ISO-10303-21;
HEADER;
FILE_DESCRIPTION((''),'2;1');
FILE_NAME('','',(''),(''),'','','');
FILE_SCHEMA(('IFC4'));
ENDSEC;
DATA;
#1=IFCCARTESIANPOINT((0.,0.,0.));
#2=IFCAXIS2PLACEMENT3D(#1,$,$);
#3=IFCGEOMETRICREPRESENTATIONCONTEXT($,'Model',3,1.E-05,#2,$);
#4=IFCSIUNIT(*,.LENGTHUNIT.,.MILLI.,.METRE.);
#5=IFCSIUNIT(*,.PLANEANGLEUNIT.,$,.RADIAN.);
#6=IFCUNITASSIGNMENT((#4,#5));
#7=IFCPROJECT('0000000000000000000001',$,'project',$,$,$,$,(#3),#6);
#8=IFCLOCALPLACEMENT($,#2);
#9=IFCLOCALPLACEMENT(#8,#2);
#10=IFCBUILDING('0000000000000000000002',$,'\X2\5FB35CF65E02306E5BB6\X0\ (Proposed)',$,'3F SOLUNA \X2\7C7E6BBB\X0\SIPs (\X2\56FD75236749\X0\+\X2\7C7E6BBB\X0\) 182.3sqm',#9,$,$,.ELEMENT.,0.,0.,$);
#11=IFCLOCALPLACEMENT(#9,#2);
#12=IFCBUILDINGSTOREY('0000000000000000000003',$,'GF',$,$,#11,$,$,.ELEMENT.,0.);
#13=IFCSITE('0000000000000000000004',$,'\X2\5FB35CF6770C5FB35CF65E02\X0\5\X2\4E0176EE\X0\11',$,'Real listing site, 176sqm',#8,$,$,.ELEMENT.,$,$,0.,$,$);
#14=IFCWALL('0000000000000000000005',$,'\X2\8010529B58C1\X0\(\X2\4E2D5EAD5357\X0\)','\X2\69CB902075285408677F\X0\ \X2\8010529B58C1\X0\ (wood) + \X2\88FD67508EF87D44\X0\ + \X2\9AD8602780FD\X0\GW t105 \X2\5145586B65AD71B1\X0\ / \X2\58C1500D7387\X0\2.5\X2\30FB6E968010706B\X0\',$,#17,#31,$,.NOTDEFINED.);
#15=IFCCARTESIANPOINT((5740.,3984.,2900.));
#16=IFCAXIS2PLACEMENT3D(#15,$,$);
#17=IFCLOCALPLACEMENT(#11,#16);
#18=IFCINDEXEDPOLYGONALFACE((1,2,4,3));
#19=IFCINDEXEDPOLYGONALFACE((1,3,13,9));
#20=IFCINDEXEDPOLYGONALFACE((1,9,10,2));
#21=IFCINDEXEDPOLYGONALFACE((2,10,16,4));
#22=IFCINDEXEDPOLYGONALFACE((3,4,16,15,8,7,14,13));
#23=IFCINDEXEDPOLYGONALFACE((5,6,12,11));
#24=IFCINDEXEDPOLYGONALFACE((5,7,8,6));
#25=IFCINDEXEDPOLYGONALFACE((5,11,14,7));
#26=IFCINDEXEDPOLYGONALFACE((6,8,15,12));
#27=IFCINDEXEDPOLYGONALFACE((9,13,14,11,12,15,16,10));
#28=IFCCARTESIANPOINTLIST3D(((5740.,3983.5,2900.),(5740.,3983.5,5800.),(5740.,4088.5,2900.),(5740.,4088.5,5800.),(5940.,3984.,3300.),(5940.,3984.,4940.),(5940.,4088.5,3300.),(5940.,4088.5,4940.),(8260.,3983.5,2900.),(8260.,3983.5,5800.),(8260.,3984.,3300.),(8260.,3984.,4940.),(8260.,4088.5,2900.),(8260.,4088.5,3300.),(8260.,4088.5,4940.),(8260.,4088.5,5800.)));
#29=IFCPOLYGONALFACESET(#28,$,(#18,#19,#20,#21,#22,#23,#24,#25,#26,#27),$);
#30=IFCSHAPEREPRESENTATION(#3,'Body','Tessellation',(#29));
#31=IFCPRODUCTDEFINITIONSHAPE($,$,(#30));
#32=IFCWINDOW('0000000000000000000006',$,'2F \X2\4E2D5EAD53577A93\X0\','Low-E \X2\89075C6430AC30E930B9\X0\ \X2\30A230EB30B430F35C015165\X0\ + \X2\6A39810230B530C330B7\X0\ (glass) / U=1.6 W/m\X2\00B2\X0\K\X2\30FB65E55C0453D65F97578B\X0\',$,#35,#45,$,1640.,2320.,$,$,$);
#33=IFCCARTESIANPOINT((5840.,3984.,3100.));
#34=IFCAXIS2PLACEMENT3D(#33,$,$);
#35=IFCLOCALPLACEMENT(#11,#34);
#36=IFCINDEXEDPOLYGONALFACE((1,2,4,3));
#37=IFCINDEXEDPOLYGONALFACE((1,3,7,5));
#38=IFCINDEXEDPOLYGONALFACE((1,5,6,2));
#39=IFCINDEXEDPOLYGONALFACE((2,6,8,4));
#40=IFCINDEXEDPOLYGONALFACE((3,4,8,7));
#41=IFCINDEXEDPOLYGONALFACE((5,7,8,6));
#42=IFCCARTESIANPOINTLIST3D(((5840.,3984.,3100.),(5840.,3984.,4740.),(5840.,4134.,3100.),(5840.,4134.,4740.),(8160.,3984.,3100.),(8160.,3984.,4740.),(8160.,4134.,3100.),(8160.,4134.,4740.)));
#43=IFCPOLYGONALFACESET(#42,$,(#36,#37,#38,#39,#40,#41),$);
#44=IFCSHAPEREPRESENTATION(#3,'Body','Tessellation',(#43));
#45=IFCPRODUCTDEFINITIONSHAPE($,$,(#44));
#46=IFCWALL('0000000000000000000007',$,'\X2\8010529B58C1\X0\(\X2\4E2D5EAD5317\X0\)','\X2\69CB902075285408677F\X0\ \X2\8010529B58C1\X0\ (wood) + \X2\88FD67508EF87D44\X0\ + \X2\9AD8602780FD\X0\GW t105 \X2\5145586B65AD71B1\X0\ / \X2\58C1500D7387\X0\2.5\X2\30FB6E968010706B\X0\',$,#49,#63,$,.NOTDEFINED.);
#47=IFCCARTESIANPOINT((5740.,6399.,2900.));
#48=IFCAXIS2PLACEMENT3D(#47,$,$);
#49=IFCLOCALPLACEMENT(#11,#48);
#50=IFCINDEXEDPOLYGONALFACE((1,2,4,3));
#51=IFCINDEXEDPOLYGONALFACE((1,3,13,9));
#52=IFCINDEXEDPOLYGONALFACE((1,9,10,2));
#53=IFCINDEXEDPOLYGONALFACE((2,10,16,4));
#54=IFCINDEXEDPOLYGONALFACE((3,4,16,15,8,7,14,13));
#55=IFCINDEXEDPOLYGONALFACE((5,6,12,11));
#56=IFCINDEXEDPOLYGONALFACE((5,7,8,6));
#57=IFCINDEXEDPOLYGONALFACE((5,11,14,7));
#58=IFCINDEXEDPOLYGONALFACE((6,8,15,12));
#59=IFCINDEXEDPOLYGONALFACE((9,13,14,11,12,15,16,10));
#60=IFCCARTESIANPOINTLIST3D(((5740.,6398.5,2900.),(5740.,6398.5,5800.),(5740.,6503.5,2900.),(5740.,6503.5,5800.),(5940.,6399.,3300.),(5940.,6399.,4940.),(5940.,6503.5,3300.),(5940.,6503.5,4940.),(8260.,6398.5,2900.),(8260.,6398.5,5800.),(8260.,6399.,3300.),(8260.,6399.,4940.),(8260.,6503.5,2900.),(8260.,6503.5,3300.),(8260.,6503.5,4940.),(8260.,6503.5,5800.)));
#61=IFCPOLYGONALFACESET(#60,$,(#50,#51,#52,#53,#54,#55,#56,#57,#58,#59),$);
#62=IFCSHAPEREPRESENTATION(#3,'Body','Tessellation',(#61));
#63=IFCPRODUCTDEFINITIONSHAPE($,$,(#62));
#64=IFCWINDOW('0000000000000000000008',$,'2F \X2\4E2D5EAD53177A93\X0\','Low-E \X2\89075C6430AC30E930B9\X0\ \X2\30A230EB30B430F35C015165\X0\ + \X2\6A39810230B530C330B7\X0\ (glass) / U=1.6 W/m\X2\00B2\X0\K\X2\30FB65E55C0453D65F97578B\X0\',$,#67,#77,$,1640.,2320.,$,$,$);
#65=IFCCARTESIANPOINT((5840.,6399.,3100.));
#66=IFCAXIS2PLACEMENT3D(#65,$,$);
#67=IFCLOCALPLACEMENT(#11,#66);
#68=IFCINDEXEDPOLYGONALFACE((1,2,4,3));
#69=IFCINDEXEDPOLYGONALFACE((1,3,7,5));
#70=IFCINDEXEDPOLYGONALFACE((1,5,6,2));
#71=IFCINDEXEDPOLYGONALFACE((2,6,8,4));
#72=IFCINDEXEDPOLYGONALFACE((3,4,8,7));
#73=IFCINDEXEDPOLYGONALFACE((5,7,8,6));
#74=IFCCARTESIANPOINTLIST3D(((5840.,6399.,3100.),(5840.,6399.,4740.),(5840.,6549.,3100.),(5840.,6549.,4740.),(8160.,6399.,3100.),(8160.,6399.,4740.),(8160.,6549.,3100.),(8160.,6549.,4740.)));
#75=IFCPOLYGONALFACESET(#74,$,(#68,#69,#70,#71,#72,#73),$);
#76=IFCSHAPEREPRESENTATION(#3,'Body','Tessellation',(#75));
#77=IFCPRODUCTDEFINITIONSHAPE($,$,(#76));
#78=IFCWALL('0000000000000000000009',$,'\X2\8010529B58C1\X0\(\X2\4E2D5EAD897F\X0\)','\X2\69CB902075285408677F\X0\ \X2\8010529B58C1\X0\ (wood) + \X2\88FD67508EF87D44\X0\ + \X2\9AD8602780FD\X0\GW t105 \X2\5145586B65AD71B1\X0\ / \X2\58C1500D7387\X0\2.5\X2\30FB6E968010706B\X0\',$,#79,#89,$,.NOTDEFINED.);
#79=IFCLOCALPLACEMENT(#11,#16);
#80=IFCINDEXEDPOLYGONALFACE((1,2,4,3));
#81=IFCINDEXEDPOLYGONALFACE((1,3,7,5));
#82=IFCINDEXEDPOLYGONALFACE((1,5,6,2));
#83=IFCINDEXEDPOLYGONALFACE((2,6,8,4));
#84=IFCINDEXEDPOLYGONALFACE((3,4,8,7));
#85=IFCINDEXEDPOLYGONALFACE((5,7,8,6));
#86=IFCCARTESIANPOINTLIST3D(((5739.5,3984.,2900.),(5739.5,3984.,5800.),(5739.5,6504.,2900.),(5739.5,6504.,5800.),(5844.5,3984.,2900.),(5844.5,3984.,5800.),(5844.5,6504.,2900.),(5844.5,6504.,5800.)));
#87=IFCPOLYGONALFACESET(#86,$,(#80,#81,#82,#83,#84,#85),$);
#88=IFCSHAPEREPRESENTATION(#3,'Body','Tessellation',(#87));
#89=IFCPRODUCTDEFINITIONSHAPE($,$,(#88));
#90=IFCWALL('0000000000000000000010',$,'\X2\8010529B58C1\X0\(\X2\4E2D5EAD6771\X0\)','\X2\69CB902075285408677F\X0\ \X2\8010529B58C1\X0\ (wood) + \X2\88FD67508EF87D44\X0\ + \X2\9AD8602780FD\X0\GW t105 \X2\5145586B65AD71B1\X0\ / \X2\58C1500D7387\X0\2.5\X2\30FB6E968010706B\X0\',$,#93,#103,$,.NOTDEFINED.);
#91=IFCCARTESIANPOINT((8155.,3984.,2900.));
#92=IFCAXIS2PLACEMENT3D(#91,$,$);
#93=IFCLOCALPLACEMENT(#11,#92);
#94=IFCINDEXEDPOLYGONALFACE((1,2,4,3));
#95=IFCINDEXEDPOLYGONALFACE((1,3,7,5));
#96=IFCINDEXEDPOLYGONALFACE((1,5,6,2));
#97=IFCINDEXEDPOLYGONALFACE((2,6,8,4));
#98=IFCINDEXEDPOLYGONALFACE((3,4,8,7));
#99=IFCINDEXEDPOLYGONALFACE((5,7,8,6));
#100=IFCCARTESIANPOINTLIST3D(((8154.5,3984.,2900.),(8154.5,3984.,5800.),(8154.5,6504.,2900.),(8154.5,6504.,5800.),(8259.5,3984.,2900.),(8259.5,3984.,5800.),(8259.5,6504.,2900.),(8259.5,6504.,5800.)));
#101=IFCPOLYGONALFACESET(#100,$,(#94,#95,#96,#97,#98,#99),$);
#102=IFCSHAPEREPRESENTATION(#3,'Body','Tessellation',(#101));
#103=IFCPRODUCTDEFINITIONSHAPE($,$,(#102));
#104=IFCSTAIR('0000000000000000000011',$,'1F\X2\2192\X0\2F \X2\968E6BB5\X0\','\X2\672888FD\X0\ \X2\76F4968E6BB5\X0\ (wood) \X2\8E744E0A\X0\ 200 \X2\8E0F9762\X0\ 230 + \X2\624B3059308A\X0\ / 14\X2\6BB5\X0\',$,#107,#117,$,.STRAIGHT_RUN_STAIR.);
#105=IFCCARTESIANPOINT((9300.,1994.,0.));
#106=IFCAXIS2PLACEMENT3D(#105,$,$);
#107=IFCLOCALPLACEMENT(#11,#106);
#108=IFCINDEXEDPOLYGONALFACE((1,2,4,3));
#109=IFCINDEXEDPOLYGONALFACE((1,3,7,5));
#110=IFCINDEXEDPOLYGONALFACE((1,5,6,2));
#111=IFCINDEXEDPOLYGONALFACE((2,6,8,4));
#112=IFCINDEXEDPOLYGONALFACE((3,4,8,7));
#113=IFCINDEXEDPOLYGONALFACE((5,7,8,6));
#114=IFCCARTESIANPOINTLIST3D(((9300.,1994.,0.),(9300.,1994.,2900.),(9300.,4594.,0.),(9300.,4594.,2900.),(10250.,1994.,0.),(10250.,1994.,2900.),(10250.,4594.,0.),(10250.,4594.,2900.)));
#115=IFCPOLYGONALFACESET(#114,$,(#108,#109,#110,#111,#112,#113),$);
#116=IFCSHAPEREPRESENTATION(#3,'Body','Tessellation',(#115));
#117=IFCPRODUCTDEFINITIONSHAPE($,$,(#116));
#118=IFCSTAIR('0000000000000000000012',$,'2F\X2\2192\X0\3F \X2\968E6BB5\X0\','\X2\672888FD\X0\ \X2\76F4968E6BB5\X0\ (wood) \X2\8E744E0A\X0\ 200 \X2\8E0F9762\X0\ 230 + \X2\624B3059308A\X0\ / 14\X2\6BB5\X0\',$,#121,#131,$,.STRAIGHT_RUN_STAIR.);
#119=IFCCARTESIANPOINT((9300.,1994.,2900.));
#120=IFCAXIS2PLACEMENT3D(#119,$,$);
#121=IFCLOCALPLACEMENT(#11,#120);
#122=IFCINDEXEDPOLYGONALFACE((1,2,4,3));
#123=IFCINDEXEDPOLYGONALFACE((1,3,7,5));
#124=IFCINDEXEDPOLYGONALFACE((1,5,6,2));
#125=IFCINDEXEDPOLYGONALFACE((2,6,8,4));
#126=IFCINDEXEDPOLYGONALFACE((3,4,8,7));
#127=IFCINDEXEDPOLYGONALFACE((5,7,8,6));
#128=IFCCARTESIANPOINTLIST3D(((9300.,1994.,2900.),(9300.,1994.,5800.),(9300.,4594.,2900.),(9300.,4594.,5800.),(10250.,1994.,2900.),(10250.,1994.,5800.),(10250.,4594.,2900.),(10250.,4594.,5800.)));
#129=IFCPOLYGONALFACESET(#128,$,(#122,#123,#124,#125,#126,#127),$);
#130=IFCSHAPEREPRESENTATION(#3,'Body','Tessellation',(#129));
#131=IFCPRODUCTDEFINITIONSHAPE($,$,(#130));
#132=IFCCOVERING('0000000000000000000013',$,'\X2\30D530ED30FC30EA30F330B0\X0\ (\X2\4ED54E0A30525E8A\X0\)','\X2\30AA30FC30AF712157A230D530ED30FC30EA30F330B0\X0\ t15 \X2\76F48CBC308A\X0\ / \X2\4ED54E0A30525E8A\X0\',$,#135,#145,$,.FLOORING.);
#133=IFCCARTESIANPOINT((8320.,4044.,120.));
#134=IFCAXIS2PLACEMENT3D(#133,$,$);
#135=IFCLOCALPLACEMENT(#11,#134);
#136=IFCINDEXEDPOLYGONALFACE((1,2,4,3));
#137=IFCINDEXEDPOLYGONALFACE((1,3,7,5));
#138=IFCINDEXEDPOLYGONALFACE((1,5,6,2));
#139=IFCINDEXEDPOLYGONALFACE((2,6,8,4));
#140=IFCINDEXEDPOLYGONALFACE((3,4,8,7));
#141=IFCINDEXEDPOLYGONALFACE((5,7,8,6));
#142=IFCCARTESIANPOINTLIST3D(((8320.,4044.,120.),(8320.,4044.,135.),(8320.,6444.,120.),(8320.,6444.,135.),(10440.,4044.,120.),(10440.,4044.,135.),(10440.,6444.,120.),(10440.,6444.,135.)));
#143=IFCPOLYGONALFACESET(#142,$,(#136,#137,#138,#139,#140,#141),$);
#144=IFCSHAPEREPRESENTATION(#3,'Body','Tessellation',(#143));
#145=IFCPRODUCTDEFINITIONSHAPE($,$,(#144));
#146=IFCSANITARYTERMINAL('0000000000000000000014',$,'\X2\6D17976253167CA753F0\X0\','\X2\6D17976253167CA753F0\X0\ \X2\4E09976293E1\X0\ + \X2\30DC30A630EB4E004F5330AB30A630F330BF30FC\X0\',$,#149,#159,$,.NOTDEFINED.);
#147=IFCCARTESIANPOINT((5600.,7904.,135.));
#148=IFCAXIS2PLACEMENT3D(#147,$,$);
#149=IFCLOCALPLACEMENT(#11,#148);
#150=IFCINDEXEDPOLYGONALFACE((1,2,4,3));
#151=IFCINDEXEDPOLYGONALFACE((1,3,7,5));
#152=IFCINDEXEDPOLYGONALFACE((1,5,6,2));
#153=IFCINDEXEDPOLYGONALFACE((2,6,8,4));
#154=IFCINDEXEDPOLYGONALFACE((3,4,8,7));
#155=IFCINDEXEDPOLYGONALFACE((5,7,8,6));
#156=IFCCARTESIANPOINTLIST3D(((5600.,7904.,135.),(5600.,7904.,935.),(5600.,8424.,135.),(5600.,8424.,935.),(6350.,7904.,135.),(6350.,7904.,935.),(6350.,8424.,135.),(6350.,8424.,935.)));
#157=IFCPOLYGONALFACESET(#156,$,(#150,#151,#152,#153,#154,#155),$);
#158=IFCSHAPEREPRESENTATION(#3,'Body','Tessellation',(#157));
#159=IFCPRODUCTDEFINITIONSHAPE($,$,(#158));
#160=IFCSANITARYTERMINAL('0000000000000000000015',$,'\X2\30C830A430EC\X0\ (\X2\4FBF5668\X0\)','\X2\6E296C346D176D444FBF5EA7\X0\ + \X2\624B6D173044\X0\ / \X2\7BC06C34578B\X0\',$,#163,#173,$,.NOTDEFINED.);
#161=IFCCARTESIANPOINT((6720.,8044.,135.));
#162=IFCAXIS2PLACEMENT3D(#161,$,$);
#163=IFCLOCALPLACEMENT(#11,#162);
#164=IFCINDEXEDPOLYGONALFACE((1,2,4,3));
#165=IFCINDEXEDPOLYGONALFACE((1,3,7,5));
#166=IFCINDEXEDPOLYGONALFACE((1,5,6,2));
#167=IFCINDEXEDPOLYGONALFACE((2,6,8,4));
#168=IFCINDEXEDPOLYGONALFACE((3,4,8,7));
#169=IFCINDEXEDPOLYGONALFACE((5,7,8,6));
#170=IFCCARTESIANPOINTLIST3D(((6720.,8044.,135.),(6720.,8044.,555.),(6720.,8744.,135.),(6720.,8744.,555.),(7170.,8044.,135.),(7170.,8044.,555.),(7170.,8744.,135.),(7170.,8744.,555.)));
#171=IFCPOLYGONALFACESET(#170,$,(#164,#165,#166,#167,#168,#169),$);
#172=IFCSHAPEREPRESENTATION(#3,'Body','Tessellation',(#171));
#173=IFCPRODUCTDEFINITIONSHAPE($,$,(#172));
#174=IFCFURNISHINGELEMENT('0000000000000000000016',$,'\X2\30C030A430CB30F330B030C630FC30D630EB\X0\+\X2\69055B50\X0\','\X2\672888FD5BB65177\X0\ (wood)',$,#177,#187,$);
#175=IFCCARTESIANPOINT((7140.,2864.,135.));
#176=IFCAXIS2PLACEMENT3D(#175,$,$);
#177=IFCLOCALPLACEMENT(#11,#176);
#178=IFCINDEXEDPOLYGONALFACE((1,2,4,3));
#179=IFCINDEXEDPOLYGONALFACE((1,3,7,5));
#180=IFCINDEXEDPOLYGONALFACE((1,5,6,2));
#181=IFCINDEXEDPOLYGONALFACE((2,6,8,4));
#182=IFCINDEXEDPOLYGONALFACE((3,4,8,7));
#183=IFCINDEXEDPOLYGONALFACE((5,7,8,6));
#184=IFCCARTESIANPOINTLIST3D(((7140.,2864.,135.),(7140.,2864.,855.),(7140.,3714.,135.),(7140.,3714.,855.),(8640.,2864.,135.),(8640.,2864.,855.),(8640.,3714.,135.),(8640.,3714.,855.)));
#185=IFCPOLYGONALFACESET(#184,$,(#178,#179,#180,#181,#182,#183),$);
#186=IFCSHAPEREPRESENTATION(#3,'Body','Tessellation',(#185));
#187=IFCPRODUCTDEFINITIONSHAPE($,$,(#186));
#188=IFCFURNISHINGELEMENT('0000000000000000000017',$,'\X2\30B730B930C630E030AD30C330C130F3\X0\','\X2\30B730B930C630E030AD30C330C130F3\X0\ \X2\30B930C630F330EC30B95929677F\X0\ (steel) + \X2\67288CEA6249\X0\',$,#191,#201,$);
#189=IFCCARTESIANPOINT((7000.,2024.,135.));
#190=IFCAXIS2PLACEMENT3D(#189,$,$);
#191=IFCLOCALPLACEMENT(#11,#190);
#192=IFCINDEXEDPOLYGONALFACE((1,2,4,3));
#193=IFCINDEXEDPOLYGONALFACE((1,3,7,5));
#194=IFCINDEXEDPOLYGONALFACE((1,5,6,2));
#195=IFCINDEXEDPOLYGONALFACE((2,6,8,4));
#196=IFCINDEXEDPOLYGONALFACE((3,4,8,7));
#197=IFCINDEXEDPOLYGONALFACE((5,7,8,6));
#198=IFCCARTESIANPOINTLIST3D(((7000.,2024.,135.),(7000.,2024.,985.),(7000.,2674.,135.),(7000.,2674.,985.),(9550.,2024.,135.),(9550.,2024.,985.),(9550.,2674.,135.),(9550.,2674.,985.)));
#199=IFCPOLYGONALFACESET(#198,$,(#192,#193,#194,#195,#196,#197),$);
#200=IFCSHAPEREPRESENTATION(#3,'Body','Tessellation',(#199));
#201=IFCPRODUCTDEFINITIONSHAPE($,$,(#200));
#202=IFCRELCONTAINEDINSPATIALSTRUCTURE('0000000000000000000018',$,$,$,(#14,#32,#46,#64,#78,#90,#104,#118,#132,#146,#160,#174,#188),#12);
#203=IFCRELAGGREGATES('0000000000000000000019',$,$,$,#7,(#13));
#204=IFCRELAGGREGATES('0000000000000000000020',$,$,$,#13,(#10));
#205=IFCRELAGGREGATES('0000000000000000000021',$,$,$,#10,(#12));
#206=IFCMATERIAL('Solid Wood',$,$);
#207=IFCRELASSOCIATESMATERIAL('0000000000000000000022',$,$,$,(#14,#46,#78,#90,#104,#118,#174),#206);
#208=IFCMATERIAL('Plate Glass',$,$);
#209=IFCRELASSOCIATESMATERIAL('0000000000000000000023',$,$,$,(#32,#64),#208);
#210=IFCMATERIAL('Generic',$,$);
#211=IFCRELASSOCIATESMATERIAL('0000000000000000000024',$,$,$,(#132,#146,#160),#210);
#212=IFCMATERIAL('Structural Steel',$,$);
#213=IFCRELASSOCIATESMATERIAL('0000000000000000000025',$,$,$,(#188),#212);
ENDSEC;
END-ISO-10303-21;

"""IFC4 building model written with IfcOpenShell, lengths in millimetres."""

from ifc_helpers import new_model, si_unit, frame, frame_2d, origin, place, context, project, spatial, rectangle, extrude, material, element, fill, save


model = new_model("IFC4")

# Units and contexts
model_context = context("Model", 3, precision=1e-05, world=origin())
ifc_project = project(units=[si_unit("LENGTHUNIT", "METRE", prefix="MILLI"), si_unit("PLANEANGLEUNIT", "RADIAN")], contexts=[model_context])

# Site, building, storey
site_placement = place(None, origin())
site = spatial("IfcSite", under=ifc_project, at=site_placement, Name="徳島県徳島市5丁目11", ObjectType="Real listing site, 176sqm", CompositionType="ELEMENT", RefElevation=0.0)
building_placement = place(site_placement, origin())
building = spatial("IfcBuilding", under=site, at=building_placement, Name="徳島市の家 (Proposed)", ObjectType="3F SOLUNA 籾殻SIPs (国産杉+籾殻) 182.3sqm", CompositionType="ELEMENT", ElevationOfRefHeight=0.0, ElevationOfTerrain=0.0)
storey_placement = place(building_placement, origin())
storey = spatial("IfcBuildingStorey", under=building, at=storey_placement, Name="GF", CompositionType="ELEMENT", Elevation=0.0)

# Shared definitions
ifc_material_1 = material(Name="Solid Wood")

# Shared definitions
ifc_material_2 = material(Name="Plate Glass")

# Walls, openings, windows
wall_1_placement = place(storey_placement, frame((5740.0, 3984.0, 2900.0)))
wall_1 = element("IfcWall", 1, at=wall_1_placement, inside=storey, material=ifc_material_1, Name="耐力壁(中庭南)", Description="構造用合板 耐力壁 (wood) + 製材軸組 + 高性能GW t105 充填断熱 / 壁倍率2.5・準耐火", PredefinedType="NOTDEFINED", context=model_context, shape_type="SweptSolid", body=[
    extrude(rectangle(XDim=2520.0, YDim=105.0, at=frame_2d((1260.0, 52.0))), frame((5740.0, 3984.0, 2900.0)), (0.0, 0.0, 1.0), 2900.0),
])
opening_1_placement = place(storey_placement, frame((5840.0, 3984.0, 3100.0)))
opening_1 = element("IfcOpeningElement", 2, at=opening_1_placement, cuts=wall_1, PredefinedType="NOTDEFINED", context=model_context, shape_type="SweptSolid", body=[
    extrude(rectangle(XDim=2320.0, YDim=150.0, at=frame_2d((1160.0, 75.0))), frame((5840.0, 3984.0, 3100.0)), (0.0, 0.0, 1.0), 1640.0),
])
window_1_placement = place(storey_placement, frame((5840.0, 3984.0, 3100.0)))
window_1 = element("IfcWindow", 3, at=window_1_placement, inside=storey, material=ifc_material_2, Name="2F 中庭南窓", Description="Low-E 複層ガラス アルゴン封入 + 樹脂サッシ (glass) / U=1.6 W/m²K・日射取得型", OverallHeight=1640.0, OverallWidth=2320.0, context=model_context, shape_type="SweptSolid", body=[
    extrude(rectangle(XDim=2320.0, YDim=150.0, at=frame_2d((1160.0, 75.0))), frame((5840.0, 3984.0, 3100.0)), (0.0, 0.0, 1.0), 1640.0),
])
fill(opening_1, window_1)
wall_2_placement = place(storey_placement, frame((5740.0, 6399.0, 2900.0)))
wall_2 = element("IfcWall", 4, at=wall_2_placement, inside=storey, material=ifc_material_1, Name="耐力壁(中庭北)", Description="構造用合板 耐力壁 (wood) + 製材軸組 + 高性能GW t105 充填断熱 / 壁倍率2.5・準耐火", PredefinedType="NOTDEFINED", context=model_context, shape_type="SweptSolid", body=[
    extrude(rectangle(XDim=2520.0, YDim=105.0, at=frame_2d((1260.0, 52.0))), frame((5740.0, 6399.0, 2900.0)), (0.0, 0.0, 1.0), 2900.0),
])
opening_2_placement = place(storey_placement, frame((5840.0, 6399.0, 3100.0)))
opening_2 = element("IfcOpeningElement", 5, at=opening_2_placement, cuts=wall_2, PredefinedType="NOTDEFINED", context=model_context, shape_type="SweptSolid", body=[
    extrude(rectangle(XDim=2320.0, YDim=150.0, at=frame_2d((1160.0, 75.0))), frame((5840.0, 6399.0, 3100.0)), (0.0, 0.0, 1.0), 1640.0),
])
window_2_placement = place(storey_placement, frame((5840.0, 6399.0, 3100.0)))
window_2 = element("IfcWindow", 6, at=window_2_placement, inside=storey, material=ifc_material_2, Name="2F 中庭北窓", Description="Low-E 複層ガラス アルゴン封入 + 樹脂サッシ (glass) / U=1.6 W/m²K・日射取得型", OverallHeight=1640.0, OverallWidth=2320.0, context=model_context, shape_type="SweptSolid", body=[
    extrude(rectangle(XDim=2320.0, YDim=150.0, at=frame_2d((1160.0, 75.0))), frame((5840.0, 6399.0, 3100.0)), (0.0, 0.0, 1.0), 1640.0),
])
fill(opening_2, window_2)

# Walls
wall_3_placement = place(storey_placement, frame((5740.0, 3984.0, 2900.0)))
element("IfcWall", 7, at=wall_3_placement, inside=storey, material=ifc_material_1, Name="耐力壁(中庭西)", Description="構造用合板 耐力壁 (wood) + 製材軸組 + 高性能GW t105 充填断熱 / 壁倍率2.5・準耐火", PredefinedType="NOTDEFINED", context=model_context, shape_type="SweptSolid", body=[
    extrude(rectangle(XDim=105.0, YDim=2520.0, at=frame_2d((52.0, 1260.0))), frame((5740.0, 3984.0, 2900.0)), (0.0, 0.0, 1.0), 2900.0),
])
wall_4_placement = place(storey_placement, frame((8155.0, 3984.0, 2900.0)))
element("IfcWall", 8, at=wall_4_placement, inside=storey, material=ifc_material_1, Name="耐力壁(中庭東)", Description="構造用合板 耐力壁 (wood) + 製材軸組 + 高性能GW t105 充填断熱 / 壁倍率2.5・準耐火", PredefinedType="NOTDEFINED", context=model_context, shape_type="SweptSolid", body=[
    extrude(rectangle(XDim=105.0, YDim=2520.0, at=frame_2d((52.0, 1260.0))), frame((8155.0, 3984.0, 2900.0)), (0.0, 0.0, 1.0), 2900.0),
])

# Stairs
stair_1_placement = place(storey_placement, frame((9300.0, 1994.0, 0.0)))
element("IfcStair", 9, at=stair_1_placement, inside=storey, material=ifc_material_1, Name="1F→2F 階段", Description="木製 直階段 (wood) 蹴上 200 踏面 230 + 手すり / 14段", PredefinedType="STRAIGHT_RUN_STAIR", context=model_context, shape_type="SweptSolid", body=[
    extrude(rectangle(XDim=950.0, YDim=2600.0, at=frame_2d((475.0, 1300.0))), frame((9300.0, 1994.0, 0.0)), (0.0, 0.0, 1.0), 2900.0),
])
stair_2_placement = place(storey_placement, frame((9300.0, 1994.0, 2900.0)))
element("IfcStair", 10, at=stair_2_placement, inside=storey, material=ifc_material_1, Name="2F→3F 階段", Description="木製 直階段 (wood) 蹴上 200 踏面 230 + 手すり / 14段", PredefinedType="STRAIGHT_RUN_STAIR", context=model_context, shape_type="SweptSolid", body=[
    extrude(rectangle(XDim=950.0, YDim=2600.0, at=frame_2d((475.0, 1300.0))), frame((9300.0, 1994.0, 2900.0)), (0.0, 0.0, 1.0), 2900.0),
])

# Covering
ifc_material_3 = material(Name="Generic")
covering_placement = place(storey_placement, frame((8320.0, 4044.0, 120.0)))
element("IfcCovering", 11, at=covering_placement, inside=storey, material=ifc_material_3, Name="フローリング (仕上げ床)", Description="オーク無垢フローリング t15 直貼り / 仕上げ床", PredefinedType="FLOORING", context=model_context, shape_type="SweptSolid", body=[
    extrude(rectangle(XDim=2120.0, YDim=2400.0, at=frame_2d((1060.0, 1200.0))), frame((8320.0, 4044.0, 120.0)), (0.0, 0.0, 1.0), 15.0),
])

# Sanitary terminals
sanitary_terminal_1_placement = place(storey_placement, frame((5600.0, 7904.0, 135.0)))
element("IfcSanitaryTerminal", 12, at=sanitary_terminal_1_placement, inside=storey, material=ifc_material_3, Name="洗面化粧台", Description="洗面化粧台 三面鏡 + ボウル一体カウンター", PredefinedType="NOTDEFINED", context=model_context, shape_type="SweptSolid", body=[
    extrude(rectangle(XDim=750.0, YDim=520.0, at=frame_2d((375.0, 260.0))), frame((5600.0, 7904.0, 135.0)), (0.0, 0.0, 1.0), 800.0),
])
sanitary_terminal_2_placement = place(storey_placement, frame((6720.0, 8044.0, 135.0)))
element("IfcSanitaryTerminal", 13, at=sanitary_terminal_2_placement, inside=storey, material=ifc_material_3, Name="トイレ (便器)", Description="温水洗浄便座 + 手洗い / 節水型", PredefinedType="NOTDEFINED", context=model_context, shape_type="SweptSolid", body=[
    extrude(rectangle(XDim=450.0, YDim=700.0, at=frame_2d((225.0, 350.0))), frame((6720.0, 8044.0, 135.0)), (0.0, 0.0, 1.0), 420.0),
])

# Furnishing elements
furnishing_1_placement = place(storey_placement, frame((7140.0, 2864.0, 135.0)))
element("IfcFurnishingElement", 14, at=furnishing_1_placement, inside=storey, material=ifc_material_1, Name="ダイニングテーブル+椅子", Description="木製家具 (wood)", context=model_context, shape_type="SweptSolid", body=[
    extrude(rectangle(XDim=1500.0, YDim=850.0, at=frame_2d((750.0, 425.0))), frame((7140.0, 2864.0, 135.0)), (0.0, 0.0, 1.0), 720.0),
])
ifc_material_4 = material(Name="Structural Steel")
furnishing_2_placement = place(storey_placement, frame((7000.0, 2024.0, 135.0)))
element("IfcFurnishingElement", 15, at=furnishing_2_placement, inside=storey, material=ifc_material_4, Name="システムキッチン", Description="システムキッチン ステンレス天板 (steel) + 木質扉", context=model_context, shape_type="SweptSolid", body=[
    extrude(rectangle(XDim=2550.0, YDim=650.0, at=frame_2d((1275.0, 325.0))), frame((7000.0, 2024.0, 135.0)), (0.0, 0.0, 1.0), 850.0),
])

save(model, "model.ifc")
